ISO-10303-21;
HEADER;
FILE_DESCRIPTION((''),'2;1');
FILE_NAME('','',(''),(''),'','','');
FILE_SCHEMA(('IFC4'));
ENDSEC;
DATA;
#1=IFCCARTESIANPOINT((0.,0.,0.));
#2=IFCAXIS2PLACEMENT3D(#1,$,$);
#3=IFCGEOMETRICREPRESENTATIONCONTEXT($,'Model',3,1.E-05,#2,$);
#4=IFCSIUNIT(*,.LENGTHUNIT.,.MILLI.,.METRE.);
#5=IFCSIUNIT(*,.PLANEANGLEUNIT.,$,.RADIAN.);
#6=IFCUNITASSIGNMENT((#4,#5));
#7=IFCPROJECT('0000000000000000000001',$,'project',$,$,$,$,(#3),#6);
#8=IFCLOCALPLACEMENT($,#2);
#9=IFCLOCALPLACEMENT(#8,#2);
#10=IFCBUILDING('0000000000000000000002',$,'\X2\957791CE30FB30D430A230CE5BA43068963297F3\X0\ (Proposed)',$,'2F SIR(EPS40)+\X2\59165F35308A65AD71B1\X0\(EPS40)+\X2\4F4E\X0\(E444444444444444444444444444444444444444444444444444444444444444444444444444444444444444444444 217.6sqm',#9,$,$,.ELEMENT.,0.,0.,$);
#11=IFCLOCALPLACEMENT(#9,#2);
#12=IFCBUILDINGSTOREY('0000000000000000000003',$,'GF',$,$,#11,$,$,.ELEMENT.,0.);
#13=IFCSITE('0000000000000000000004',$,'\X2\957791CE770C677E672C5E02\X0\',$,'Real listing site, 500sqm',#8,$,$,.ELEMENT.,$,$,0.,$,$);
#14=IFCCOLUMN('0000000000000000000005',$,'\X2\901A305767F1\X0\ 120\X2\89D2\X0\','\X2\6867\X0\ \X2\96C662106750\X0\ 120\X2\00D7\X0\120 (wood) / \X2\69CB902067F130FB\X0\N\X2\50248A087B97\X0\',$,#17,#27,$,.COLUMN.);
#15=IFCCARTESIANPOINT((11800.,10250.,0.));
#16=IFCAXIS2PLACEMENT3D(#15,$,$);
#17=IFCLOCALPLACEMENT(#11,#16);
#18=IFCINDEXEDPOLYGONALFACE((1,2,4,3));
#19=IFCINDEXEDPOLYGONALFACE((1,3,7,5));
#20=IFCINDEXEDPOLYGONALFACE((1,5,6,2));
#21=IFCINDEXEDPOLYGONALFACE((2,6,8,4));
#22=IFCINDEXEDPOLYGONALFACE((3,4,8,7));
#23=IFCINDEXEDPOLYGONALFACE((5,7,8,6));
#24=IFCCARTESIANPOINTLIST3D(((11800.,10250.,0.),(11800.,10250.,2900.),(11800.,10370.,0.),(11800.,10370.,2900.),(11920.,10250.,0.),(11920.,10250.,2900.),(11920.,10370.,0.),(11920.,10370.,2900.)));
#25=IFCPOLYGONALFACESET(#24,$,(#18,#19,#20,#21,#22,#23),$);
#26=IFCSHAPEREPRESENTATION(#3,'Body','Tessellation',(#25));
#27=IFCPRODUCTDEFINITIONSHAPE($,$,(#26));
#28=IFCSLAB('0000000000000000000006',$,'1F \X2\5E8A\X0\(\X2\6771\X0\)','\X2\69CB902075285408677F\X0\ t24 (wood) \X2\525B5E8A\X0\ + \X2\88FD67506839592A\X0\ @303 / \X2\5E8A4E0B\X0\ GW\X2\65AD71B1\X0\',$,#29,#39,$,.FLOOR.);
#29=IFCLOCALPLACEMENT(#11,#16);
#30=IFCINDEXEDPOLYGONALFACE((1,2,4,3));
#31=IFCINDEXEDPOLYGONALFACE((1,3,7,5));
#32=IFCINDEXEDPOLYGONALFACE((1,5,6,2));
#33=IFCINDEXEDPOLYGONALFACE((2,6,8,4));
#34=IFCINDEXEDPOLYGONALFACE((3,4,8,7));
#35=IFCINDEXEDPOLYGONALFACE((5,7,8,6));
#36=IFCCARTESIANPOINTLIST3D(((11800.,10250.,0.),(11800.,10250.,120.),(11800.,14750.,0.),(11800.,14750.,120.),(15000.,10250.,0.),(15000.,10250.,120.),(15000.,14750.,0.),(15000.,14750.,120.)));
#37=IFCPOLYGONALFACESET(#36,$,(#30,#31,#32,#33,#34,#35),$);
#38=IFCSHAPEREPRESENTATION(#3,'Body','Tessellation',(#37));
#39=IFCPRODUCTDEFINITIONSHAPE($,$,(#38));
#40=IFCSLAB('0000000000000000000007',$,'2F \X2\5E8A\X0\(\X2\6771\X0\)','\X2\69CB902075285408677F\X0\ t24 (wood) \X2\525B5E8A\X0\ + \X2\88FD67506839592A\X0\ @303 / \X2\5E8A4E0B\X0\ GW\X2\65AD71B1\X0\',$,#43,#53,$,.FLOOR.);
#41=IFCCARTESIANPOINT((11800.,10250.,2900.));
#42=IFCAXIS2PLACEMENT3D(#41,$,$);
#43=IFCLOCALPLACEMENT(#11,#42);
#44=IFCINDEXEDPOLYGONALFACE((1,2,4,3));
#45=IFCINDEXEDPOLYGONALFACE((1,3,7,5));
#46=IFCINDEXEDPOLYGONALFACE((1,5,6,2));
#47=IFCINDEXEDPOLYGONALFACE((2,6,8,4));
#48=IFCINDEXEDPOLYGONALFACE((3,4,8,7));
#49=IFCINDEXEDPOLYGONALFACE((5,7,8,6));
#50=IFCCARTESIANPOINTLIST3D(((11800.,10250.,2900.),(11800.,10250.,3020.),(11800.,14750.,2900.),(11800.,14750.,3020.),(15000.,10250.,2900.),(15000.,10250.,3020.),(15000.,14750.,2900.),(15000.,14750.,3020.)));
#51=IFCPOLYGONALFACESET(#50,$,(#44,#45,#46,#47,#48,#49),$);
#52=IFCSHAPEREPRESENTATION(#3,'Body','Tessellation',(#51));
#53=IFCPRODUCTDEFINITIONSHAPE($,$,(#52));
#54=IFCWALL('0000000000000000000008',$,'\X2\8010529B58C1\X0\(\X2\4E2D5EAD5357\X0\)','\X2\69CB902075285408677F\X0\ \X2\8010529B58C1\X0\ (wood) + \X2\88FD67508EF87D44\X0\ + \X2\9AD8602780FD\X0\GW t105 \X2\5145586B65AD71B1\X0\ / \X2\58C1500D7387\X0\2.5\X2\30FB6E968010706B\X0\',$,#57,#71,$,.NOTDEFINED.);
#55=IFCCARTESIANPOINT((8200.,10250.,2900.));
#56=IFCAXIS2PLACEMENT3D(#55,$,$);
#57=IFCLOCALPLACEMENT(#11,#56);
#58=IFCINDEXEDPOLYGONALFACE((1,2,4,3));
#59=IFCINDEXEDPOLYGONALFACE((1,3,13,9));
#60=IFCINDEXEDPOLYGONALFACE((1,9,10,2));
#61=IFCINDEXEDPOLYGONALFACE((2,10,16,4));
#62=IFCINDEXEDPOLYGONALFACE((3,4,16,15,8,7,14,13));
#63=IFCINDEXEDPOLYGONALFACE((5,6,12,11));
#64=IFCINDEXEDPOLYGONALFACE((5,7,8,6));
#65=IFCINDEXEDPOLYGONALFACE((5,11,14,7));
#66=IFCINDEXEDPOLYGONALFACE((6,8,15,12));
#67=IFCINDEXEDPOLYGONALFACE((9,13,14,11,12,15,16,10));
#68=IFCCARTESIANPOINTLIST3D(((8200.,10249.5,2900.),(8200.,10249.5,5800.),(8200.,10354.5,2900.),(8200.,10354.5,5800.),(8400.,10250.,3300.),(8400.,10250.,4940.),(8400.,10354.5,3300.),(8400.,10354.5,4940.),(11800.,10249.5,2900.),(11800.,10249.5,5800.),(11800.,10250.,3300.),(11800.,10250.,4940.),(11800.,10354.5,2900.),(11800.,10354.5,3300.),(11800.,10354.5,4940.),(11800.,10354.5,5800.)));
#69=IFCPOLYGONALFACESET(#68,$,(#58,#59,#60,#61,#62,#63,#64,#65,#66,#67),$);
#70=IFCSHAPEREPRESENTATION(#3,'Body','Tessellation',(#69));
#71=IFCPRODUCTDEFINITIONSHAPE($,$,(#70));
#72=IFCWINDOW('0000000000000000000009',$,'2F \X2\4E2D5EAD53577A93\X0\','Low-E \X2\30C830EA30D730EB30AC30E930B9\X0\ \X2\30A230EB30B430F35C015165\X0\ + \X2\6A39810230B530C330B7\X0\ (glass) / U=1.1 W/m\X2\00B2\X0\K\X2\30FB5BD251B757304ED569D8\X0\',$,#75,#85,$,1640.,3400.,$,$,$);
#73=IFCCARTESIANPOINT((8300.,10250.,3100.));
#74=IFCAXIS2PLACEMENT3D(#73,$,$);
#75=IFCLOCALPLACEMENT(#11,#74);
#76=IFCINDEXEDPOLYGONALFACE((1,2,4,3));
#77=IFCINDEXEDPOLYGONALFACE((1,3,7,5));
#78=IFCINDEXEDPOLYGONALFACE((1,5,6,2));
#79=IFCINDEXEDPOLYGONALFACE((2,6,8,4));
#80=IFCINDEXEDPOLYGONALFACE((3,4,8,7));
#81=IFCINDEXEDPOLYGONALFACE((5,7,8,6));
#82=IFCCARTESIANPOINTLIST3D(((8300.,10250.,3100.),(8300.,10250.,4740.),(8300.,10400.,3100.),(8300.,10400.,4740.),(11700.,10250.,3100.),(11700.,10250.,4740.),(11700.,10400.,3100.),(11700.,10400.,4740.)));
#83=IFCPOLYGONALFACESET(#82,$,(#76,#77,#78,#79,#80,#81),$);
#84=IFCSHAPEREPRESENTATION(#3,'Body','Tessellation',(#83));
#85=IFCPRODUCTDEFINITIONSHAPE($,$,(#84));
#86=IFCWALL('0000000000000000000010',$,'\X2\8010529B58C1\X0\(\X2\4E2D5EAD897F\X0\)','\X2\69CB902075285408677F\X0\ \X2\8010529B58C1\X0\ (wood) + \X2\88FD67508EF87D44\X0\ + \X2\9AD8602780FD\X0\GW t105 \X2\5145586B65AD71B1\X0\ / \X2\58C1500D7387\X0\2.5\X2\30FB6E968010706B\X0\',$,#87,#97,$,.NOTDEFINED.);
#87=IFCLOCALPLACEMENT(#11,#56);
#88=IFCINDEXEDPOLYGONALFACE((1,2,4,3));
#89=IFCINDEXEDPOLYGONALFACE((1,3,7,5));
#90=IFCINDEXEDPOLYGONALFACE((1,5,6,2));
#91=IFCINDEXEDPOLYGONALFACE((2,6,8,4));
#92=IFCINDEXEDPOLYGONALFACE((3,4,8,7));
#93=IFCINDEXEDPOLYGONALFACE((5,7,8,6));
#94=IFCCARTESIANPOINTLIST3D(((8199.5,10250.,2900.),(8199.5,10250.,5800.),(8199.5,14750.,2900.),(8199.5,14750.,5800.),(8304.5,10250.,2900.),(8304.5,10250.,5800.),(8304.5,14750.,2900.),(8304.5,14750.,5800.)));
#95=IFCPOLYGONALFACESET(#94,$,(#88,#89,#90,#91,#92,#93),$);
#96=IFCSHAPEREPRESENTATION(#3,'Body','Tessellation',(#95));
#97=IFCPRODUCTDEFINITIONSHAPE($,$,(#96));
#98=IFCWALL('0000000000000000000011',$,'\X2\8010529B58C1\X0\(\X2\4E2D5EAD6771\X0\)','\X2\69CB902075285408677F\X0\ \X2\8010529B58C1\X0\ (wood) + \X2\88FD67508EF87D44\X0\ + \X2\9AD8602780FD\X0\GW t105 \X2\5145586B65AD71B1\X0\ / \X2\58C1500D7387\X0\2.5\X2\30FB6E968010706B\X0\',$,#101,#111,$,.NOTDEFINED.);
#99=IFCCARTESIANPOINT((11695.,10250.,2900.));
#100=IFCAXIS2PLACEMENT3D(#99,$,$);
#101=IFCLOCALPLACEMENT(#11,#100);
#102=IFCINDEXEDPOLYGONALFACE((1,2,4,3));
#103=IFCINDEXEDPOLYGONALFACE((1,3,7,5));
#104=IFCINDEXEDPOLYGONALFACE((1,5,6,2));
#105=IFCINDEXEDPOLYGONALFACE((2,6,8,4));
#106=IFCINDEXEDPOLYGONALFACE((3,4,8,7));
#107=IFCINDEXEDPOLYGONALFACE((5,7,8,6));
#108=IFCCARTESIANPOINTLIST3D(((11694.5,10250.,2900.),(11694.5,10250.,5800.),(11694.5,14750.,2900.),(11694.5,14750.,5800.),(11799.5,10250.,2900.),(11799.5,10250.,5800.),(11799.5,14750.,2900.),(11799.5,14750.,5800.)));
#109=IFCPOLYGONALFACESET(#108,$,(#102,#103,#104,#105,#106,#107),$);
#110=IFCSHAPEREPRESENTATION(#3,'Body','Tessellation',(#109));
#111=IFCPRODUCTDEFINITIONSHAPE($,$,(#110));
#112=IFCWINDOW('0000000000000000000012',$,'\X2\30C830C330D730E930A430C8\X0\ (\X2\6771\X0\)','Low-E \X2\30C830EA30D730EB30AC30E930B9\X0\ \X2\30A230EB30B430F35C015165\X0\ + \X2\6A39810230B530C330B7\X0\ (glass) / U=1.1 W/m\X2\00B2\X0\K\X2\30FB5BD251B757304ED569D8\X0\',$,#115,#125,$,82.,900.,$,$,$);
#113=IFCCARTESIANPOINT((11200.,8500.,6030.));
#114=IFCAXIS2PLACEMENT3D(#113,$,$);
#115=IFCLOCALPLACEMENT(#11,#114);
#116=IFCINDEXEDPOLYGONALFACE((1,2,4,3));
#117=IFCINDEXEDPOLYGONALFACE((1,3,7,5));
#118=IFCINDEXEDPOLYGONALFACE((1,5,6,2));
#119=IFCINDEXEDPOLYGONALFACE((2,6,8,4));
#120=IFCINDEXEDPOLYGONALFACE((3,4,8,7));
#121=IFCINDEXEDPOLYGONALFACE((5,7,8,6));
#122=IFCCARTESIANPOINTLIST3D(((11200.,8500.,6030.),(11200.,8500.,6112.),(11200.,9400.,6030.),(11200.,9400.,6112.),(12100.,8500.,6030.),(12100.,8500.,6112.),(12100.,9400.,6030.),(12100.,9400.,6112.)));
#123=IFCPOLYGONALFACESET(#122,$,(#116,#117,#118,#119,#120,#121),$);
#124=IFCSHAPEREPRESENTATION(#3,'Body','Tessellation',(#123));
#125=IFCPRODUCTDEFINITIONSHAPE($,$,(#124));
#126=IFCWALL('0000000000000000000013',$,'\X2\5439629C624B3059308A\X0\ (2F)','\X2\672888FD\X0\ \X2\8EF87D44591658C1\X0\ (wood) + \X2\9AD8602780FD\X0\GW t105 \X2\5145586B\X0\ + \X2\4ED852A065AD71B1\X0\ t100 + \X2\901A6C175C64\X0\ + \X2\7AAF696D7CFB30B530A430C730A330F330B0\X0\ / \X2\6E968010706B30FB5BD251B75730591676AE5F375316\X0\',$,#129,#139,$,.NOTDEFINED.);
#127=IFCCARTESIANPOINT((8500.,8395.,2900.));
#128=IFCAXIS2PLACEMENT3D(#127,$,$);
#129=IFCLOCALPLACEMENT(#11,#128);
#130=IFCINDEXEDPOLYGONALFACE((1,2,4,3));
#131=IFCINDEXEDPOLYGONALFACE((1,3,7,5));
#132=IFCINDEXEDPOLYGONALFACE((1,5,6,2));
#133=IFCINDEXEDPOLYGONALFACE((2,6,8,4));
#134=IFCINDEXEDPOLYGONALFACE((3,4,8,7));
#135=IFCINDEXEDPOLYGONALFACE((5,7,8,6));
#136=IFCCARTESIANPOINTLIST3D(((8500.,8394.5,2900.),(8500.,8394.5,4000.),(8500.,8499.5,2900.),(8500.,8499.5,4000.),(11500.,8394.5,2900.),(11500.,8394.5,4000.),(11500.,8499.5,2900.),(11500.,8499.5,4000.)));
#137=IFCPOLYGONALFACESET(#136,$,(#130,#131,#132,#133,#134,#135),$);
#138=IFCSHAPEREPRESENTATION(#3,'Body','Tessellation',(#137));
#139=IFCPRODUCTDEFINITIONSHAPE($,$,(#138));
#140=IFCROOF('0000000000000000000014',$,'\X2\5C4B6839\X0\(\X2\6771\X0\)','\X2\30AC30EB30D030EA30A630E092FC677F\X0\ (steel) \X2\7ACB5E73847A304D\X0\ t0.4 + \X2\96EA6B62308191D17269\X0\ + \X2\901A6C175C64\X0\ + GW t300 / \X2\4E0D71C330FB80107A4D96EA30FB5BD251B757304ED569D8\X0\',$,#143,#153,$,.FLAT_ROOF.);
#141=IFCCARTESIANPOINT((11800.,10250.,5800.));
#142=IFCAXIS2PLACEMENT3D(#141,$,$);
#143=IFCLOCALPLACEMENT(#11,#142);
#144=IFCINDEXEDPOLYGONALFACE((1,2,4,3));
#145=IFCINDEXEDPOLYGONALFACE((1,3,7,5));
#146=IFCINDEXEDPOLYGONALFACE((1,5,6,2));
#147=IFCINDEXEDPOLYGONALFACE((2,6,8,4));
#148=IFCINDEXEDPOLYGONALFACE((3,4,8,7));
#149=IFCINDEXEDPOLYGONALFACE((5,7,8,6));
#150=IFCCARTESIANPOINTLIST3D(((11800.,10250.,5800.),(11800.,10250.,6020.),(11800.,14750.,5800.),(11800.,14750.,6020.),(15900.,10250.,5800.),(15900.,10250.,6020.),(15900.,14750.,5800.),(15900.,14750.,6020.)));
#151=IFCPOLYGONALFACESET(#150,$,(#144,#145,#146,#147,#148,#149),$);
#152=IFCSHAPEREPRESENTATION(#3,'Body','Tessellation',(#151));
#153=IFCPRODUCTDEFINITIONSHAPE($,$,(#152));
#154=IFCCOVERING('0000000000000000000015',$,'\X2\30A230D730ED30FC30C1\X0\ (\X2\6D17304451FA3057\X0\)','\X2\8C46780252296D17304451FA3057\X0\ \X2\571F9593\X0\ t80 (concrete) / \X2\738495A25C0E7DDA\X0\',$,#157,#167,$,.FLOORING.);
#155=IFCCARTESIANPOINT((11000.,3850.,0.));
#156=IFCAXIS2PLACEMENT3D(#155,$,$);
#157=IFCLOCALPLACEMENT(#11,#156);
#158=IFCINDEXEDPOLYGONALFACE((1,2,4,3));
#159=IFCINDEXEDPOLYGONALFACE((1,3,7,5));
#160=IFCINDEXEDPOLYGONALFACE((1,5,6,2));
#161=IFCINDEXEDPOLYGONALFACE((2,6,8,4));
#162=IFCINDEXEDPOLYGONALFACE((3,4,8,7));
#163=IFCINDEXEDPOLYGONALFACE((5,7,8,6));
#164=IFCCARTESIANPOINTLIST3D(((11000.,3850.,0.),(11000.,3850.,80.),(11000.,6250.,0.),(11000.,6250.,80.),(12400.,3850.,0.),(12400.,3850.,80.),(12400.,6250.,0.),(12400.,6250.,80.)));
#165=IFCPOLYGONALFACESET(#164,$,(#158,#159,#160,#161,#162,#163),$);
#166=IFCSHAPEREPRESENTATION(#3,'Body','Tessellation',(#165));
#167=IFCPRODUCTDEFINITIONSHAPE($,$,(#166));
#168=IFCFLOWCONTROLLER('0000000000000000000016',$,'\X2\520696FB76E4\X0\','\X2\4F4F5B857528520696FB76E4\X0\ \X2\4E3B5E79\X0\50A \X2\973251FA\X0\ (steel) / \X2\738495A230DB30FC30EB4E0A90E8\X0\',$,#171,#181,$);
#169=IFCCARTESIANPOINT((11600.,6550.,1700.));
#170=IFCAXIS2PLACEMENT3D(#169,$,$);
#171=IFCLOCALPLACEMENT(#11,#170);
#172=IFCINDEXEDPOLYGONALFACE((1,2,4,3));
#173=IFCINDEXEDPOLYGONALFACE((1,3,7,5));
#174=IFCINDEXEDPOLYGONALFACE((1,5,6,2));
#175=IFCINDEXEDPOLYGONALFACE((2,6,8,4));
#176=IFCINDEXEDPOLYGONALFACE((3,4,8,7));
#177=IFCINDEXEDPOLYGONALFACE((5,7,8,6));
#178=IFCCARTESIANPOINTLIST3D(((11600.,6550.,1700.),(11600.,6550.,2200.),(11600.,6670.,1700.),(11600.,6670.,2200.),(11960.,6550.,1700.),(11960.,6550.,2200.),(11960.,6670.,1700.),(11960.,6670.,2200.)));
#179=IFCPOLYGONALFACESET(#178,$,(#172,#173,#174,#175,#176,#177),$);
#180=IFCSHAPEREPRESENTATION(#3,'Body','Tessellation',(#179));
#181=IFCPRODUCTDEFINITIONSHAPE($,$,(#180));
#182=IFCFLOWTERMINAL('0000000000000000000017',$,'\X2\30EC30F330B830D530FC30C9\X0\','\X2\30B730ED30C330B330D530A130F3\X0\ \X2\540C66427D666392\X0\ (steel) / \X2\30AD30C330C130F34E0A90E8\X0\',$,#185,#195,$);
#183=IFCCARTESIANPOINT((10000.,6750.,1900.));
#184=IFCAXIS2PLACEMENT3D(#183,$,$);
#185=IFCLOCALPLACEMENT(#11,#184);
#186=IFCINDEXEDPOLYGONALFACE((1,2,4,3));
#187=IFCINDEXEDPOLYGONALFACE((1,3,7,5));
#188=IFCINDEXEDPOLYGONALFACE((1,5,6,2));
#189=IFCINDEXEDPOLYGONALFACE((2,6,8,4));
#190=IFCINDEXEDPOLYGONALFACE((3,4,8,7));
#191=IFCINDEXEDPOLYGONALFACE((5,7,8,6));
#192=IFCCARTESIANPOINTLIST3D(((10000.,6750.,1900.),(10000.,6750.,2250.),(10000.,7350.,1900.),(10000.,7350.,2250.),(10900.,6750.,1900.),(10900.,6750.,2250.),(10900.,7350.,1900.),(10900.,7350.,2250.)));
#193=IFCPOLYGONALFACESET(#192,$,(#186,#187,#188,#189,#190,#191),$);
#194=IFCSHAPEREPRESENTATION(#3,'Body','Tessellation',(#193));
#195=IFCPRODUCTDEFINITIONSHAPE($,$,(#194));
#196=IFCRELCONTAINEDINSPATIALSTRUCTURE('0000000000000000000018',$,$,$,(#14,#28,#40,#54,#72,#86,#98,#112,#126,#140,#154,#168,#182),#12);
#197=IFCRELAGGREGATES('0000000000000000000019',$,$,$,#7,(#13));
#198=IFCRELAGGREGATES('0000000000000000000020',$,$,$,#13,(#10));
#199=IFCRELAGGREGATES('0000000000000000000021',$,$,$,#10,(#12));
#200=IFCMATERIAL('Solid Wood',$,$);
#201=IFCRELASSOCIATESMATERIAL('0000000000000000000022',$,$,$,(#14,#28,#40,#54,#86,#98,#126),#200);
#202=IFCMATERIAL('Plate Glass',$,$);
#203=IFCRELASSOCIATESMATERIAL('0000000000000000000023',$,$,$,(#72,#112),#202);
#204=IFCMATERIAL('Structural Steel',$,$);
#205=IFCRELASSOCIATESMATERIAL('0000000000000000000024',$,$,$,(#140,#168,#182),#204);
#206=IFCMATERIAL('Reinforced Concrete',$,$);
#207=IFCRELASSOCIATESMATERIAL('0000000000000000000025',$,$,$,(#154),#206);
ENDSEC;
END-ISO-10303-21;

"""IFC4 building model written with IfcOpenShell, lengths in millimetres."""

from ifc_helpers import new_model, si_unit, frame, frame_2d, origin, place, context, project, spatial, rectangle, extrude, material, element, fill, save


model = new_model("IFC4")

# Units and contexts
model_context = context("Model", 3, precision=1e-05, world=origin())
ifc_project = project(units=[si_unit("LENGTHUNIT", "METRE", prefix="MILLI"), si_unit("PLANEANGLEUNIT", "RADIAN")], contexts=[model_context])

# Site, building, storey
site_placement = place(None, origin())
site = spatial("IfcSite", under=ifc_project, at=site_placement, Name="長野県松本市", ObjectType="Real listing site, 500sqm", CompositionType="ELEMENT", RefElevation=0.0)
building_placement = place(site_placement, origin())
building = spatial("IfcBuilding", under=site, at=building_placement, Name="長野・ピアノ室と防音 (Proposed)", ObjectType="2F SIR(EPS40)+外張り断熱(EPS40)+低(E444444444444444444444444444444444444444444444444444444444444444444444444444444444444444444444 217.6sqm", CompositionType="ELEMENT", ElevationOfRefHeight=0.0, ElevationOfTerrain=0.0)
storey_placement = place(building_placement, origin())
storey = spatial("IfcBuildingStorey", under=building, at=storey_placement, Name="GF", CompositionType="ELEMENT", Elevation=0.0)

# Column
ifc_material_1 = material(Name="Solid Wood")
column_1_placement = place(storey_placement, frame((11800.0, 10250.0, 0.0)))
element("IfcColumn", 1, at=column_1_placement, inside=storey, material=ifc_material_1, Name="通し柱 120角", Description="桧 集成材 120×120 (wood) / 構造柱・N値計算", PredefinedType="COLUMN", context=model_context, shape_type="SweptSolid", body=[
    extrude(rectangle(XDim=120.0, YDim=120.0, at=frame_2d((60.0, 60.0))), frame((11800.0, 10250.0, 0.0)), (0.0, 0.0, 1.0), 2900.0),
])

# Slabs
slab_1_placement = place(storey_placement, frame((11800.0, 10250.0, 0.0)))
element("IfcSlab", 2, at=slab_1_placement, inside=storey, material=ifc_material_1, Name="1F 床(東)", Description="構造用合板 t24 (wood) 剛床 + 製材根太 @303 / 床下 GW断熱", PredefinedType="FLOOR", context=model_context, shape_type="SweptSolid", body=[
    extrude(rectangle(XDim=3200.0, YDim=4500.0, at=frame_2d((1600.0, 2250.0))), frame((11800.0, 10250.0, 0.0)), (0.0, 0.0, 1.0), 120.0),
])
slab_2_placement = place(storey_placement, frame((11800.0, 10250.0, 2900.0)))
element("IfcSlab", 3, at=slab_2_placement, inside=storey, material=ifc_material_1, Name="2F 床(東)", Description="構造用合板 t24 (wood) 剛床 + 製材根太 @303 / 床下 GW断熱", PredefinedType="FLOOR", context=model_context, shape_type="SweptSolid", body=[
    extrude(rectangle(XDim=3200.0, YDim=4500.0, at=frame_2d((1600.0, 2250.0))), frame((11800.0, 10250.0, 2900.0)), (0.0, 0.0, 1.0), 120.0),
])

# Wall, opening, window
wall_1_placement = place(storey_placement, frame((8200.0, 10250.0, 2900.0)))
wall_1 = element("IfcWall", 4, at=wall_1_placement, inside=storey, material=ifc_material_1, Name="耐力壁(中庭南)", Description="構造用合板 耐力壁 (wood) + 製材軸組 + 高性能GW t105 充填断熱 / 壁倍率2.5・準耐火", PredefinedType="NOTDEFINED", context=model_context, shape_type="SweptSolid", body=[
    extrude(rectangle(XDim=3600.0, YDim=105.0, at=frame_2d((1800.0, 52.0))), frame((8200.0, 10250.0, 2900.0)), (0.0, 0.0, 1.0), 2900.0),
])
opening_placement = place(storey_placement, frame((8300.0, 10250.0, 3100.0)))
opening = element("IfcOpeningElement", 5, at=opening_placement, cuts=wall_1, PredefinedType="NOTDEFINED", context=model_context, shape_type="SweptSolid", body=[
    extrude(rectangle(XDim=3400.0, YDim=150.0, at=frame_2d((1700.0, 75.0))), frame((8300.0, 10250.0, 3100.0)), (0.0, 0.0, 1.0), 1640.0),
])
ifc_material_2 = material(Name="Plate Glass")
window_1_placement = place(storey_placement, frame((8300.0, 10250.0, 3100.0)))
window_1 = element("IfcWindow", 6, at=window_1_placement, inside=storey, material=ifc_material_2, Name="2F 中庭南窓", Description="Low-E トリプルガラス アルゴン封入 + 樹脂サッシ (glass) / U=1.1 W/m²K・寒冷地仕様", OverallHeight=1640.0, OverallWidth=3400.0, context=model_context, shape_type="SweptSolid", body=[
    extrude(rectangle(XDim=3400.0, YDim=150.0, at=frame_2d((1700.0, 75.0))), frame((8300.0, 10250.0, 3100.0)), (0.0, 0.0, 1.0), 1640.0),
])
fill(opening, window_1)

# Walls
wall_2_placement = place(storey_placement, frame((8200.0, 10250.0, 2900.0)))
element("IfcWall", 7, at=wall_2_placement, inside=storey, material=ifc_material_1, Name="耐力壁(中庭西)", Description="構造用合板 耐力壁 (wood) + 製材軸組 + 高性能GW t105 充填断熱 / 壁倍率2.5・準耐火", PredefinedType="NOTDEFINED", context=model_context, shape_type="SweptSolid", body=[
    extrude(rectangle(XDim=105.0, YDim=4500.0, at=frame_2d((52.0, 2250.0))), frame((8200.0, 10250.0, 2900.0)), (0.0, 0.0, 1.0), 2900.0),
])
wall_3_placement = place(storey_placement, frame((11695.0, 10250.0, 2900.0)))
element("IfcWall", 8, at=wall_3_placement, inside=storey, material=ifc_material_1, Name="耐力壁(中庭東)", Description="構造用合板 耐力壁 (wood) + 製材軸組 + 高性能GW t105 充填断熱 / 壁倍率2.5・準耐火", PredefinedType="NOTDEFINED", context=model_context, shape_type="SweptSolid", body=[
    extrude(rectangle(XDim=105.0, YDim=4500.0, at=frame_2d((52.0, 2250.0))), frame((11695.0, 10250.0, 2900.0)), (0.0, 0.0, 1.0), 2900.0),
])

# Window
window_2_placement = place(storey_placement, frame((11200.0, 8500.0, 6030.0)))
element("IfcWindow", 9, at=window_2_placement, inside=storey, material=ifc_material_2, Name="トップライト (東)", Description="Low-E トリプルガラス アルゴン封入 + 樹脂サッシ (glass) / U=1.1 W/m²K・寒冷地仕様", OverallHeight=82.0, OverallWidth=900.0, context=model_context, shape_type="SweptSolid", body=[
    extrude(rectangle(XDim=900.0, YDim=900.0, at=frame_2d((450.0, 450.0))), frame((11200.0, 8500.0, 6030.0)), (0.0, 0.0, 1.0), 82.0),
])

# Wall
wall_4_placement = place(storey_placement, frame((8500.0, 8395.0, 2900.0)))
element("IfcWall", 10, at=wall_4_placement, inside=storey, material=ifc_material_1, Name="吹抜手すり (2F)", Description="木製 軸組外壁 (wood) + 高性能GW t105 充填 + 付加断熱 t100 + 通気層 + 窯業系サイディング / 準耐火・寒冷地外皮強化", PredefinedType="NOTDEFINED", context=model_context, shape_type="SweptSolid", body=[
    extrude(rectangle(XDim=3000.0, YDim=105.0, at=frame_2d((1500.0, 52.0))), frame((8500.0, 8395.0, 2900.0)), (0.0, 0.0, 1.0), 1100.0),
])

# Roof
ifc_material_3 = material(Name="Structural Steel")
for number, where, name in (
    (11, (11800.0, 10250.0, 5800.0), "屋根(東)"),
):
    element("IfcRoof", number, at=place(storey_placement, frame(where)), inside=storey, material=ifc_material_3, Name=name, Description="ガルバリウム鋼板 (steel) 立平葺き t0.4 + 雪止め金物 + 通気層 + GW t300 / 不燃・耐積雪・寒冷地仕様", PredefinedType="FLAT_ROOF", context=model_context, shape_type="SweptSolid", body=[
        extrude(rectangle(XDim=4100.0, YDim=4500.0, at=frame_2d((2050.0, 2250.0))), frame((11800.0, 10250.0, 5800.0)), (0.0, 0.0, 1.0), 220.0),
    ])

# Covering
ifc_material_4 = material(Name="Reinforced Concrete")
covering_placement = place(storey_placement, frame((11000.0, 3850.0, 0.0)))
element("IfcCovering", 12, at=covering_placement, inside=storey, material=ifc_material_4, Name="アプローチ (洗い出し)", Description="豆砂利洗い出し 土間 t80 (concrete) / 玄関導線", PredefinedType="FLOORING", context=model_context, shape_type="SweptSolid", body=[
    extrude(rectangle(XDim=1400.0, YDim=2400.0, at=frame_2d((700.0, 1200.0))), frame((11000.0, 3850.0, 0.0)), (0.0, 0.0, 1.0), 80.0),
])

# Flow controller
flow_controller_placement = place(storey_placement, frame((11600.0, 6550.0, 1700.0)))
element("IfcFlowController", 13, at=flow_controller_placement, inside=storey, material=ifc_material_3, Name="分電盤", Description="住宅用分電盤 主幹50A 露出 (steel) / 玄関ホール上部", context=model_context, shape_type="SweptSolid", body=[
    extrude(rectangle(XDim=360.0, YDim=120.0, at=frame_2d((180.0, 60.0))), frame((11600.0, 6550.0, 1700.0)), (0.0, 0.0, 1.0), 500.0),
])

# Flow terminal
flow_terminal_1_placement = place(storey_placement, frame((10000.0, 6750.0, 1900.0)))
element("IfcFlowTerminal", 14, at=flow_terminal_1_placement, inside=storey, material=ifc_material_3, Name="レンジフード", Description="シロッコファン 同時給排 (steel) / キッチン上部", context=model_context, shape_type="SweptSolid", body=[
    extrude(rectangle(XDim=900.0, YDim=600.0, at=frame_2d((450.0, 300.0))), frame((10000.0, 6750.0, 1900.0)), (0.0, 0.0, 1.0), 350.0),
])

save(model, "model.ifc")
